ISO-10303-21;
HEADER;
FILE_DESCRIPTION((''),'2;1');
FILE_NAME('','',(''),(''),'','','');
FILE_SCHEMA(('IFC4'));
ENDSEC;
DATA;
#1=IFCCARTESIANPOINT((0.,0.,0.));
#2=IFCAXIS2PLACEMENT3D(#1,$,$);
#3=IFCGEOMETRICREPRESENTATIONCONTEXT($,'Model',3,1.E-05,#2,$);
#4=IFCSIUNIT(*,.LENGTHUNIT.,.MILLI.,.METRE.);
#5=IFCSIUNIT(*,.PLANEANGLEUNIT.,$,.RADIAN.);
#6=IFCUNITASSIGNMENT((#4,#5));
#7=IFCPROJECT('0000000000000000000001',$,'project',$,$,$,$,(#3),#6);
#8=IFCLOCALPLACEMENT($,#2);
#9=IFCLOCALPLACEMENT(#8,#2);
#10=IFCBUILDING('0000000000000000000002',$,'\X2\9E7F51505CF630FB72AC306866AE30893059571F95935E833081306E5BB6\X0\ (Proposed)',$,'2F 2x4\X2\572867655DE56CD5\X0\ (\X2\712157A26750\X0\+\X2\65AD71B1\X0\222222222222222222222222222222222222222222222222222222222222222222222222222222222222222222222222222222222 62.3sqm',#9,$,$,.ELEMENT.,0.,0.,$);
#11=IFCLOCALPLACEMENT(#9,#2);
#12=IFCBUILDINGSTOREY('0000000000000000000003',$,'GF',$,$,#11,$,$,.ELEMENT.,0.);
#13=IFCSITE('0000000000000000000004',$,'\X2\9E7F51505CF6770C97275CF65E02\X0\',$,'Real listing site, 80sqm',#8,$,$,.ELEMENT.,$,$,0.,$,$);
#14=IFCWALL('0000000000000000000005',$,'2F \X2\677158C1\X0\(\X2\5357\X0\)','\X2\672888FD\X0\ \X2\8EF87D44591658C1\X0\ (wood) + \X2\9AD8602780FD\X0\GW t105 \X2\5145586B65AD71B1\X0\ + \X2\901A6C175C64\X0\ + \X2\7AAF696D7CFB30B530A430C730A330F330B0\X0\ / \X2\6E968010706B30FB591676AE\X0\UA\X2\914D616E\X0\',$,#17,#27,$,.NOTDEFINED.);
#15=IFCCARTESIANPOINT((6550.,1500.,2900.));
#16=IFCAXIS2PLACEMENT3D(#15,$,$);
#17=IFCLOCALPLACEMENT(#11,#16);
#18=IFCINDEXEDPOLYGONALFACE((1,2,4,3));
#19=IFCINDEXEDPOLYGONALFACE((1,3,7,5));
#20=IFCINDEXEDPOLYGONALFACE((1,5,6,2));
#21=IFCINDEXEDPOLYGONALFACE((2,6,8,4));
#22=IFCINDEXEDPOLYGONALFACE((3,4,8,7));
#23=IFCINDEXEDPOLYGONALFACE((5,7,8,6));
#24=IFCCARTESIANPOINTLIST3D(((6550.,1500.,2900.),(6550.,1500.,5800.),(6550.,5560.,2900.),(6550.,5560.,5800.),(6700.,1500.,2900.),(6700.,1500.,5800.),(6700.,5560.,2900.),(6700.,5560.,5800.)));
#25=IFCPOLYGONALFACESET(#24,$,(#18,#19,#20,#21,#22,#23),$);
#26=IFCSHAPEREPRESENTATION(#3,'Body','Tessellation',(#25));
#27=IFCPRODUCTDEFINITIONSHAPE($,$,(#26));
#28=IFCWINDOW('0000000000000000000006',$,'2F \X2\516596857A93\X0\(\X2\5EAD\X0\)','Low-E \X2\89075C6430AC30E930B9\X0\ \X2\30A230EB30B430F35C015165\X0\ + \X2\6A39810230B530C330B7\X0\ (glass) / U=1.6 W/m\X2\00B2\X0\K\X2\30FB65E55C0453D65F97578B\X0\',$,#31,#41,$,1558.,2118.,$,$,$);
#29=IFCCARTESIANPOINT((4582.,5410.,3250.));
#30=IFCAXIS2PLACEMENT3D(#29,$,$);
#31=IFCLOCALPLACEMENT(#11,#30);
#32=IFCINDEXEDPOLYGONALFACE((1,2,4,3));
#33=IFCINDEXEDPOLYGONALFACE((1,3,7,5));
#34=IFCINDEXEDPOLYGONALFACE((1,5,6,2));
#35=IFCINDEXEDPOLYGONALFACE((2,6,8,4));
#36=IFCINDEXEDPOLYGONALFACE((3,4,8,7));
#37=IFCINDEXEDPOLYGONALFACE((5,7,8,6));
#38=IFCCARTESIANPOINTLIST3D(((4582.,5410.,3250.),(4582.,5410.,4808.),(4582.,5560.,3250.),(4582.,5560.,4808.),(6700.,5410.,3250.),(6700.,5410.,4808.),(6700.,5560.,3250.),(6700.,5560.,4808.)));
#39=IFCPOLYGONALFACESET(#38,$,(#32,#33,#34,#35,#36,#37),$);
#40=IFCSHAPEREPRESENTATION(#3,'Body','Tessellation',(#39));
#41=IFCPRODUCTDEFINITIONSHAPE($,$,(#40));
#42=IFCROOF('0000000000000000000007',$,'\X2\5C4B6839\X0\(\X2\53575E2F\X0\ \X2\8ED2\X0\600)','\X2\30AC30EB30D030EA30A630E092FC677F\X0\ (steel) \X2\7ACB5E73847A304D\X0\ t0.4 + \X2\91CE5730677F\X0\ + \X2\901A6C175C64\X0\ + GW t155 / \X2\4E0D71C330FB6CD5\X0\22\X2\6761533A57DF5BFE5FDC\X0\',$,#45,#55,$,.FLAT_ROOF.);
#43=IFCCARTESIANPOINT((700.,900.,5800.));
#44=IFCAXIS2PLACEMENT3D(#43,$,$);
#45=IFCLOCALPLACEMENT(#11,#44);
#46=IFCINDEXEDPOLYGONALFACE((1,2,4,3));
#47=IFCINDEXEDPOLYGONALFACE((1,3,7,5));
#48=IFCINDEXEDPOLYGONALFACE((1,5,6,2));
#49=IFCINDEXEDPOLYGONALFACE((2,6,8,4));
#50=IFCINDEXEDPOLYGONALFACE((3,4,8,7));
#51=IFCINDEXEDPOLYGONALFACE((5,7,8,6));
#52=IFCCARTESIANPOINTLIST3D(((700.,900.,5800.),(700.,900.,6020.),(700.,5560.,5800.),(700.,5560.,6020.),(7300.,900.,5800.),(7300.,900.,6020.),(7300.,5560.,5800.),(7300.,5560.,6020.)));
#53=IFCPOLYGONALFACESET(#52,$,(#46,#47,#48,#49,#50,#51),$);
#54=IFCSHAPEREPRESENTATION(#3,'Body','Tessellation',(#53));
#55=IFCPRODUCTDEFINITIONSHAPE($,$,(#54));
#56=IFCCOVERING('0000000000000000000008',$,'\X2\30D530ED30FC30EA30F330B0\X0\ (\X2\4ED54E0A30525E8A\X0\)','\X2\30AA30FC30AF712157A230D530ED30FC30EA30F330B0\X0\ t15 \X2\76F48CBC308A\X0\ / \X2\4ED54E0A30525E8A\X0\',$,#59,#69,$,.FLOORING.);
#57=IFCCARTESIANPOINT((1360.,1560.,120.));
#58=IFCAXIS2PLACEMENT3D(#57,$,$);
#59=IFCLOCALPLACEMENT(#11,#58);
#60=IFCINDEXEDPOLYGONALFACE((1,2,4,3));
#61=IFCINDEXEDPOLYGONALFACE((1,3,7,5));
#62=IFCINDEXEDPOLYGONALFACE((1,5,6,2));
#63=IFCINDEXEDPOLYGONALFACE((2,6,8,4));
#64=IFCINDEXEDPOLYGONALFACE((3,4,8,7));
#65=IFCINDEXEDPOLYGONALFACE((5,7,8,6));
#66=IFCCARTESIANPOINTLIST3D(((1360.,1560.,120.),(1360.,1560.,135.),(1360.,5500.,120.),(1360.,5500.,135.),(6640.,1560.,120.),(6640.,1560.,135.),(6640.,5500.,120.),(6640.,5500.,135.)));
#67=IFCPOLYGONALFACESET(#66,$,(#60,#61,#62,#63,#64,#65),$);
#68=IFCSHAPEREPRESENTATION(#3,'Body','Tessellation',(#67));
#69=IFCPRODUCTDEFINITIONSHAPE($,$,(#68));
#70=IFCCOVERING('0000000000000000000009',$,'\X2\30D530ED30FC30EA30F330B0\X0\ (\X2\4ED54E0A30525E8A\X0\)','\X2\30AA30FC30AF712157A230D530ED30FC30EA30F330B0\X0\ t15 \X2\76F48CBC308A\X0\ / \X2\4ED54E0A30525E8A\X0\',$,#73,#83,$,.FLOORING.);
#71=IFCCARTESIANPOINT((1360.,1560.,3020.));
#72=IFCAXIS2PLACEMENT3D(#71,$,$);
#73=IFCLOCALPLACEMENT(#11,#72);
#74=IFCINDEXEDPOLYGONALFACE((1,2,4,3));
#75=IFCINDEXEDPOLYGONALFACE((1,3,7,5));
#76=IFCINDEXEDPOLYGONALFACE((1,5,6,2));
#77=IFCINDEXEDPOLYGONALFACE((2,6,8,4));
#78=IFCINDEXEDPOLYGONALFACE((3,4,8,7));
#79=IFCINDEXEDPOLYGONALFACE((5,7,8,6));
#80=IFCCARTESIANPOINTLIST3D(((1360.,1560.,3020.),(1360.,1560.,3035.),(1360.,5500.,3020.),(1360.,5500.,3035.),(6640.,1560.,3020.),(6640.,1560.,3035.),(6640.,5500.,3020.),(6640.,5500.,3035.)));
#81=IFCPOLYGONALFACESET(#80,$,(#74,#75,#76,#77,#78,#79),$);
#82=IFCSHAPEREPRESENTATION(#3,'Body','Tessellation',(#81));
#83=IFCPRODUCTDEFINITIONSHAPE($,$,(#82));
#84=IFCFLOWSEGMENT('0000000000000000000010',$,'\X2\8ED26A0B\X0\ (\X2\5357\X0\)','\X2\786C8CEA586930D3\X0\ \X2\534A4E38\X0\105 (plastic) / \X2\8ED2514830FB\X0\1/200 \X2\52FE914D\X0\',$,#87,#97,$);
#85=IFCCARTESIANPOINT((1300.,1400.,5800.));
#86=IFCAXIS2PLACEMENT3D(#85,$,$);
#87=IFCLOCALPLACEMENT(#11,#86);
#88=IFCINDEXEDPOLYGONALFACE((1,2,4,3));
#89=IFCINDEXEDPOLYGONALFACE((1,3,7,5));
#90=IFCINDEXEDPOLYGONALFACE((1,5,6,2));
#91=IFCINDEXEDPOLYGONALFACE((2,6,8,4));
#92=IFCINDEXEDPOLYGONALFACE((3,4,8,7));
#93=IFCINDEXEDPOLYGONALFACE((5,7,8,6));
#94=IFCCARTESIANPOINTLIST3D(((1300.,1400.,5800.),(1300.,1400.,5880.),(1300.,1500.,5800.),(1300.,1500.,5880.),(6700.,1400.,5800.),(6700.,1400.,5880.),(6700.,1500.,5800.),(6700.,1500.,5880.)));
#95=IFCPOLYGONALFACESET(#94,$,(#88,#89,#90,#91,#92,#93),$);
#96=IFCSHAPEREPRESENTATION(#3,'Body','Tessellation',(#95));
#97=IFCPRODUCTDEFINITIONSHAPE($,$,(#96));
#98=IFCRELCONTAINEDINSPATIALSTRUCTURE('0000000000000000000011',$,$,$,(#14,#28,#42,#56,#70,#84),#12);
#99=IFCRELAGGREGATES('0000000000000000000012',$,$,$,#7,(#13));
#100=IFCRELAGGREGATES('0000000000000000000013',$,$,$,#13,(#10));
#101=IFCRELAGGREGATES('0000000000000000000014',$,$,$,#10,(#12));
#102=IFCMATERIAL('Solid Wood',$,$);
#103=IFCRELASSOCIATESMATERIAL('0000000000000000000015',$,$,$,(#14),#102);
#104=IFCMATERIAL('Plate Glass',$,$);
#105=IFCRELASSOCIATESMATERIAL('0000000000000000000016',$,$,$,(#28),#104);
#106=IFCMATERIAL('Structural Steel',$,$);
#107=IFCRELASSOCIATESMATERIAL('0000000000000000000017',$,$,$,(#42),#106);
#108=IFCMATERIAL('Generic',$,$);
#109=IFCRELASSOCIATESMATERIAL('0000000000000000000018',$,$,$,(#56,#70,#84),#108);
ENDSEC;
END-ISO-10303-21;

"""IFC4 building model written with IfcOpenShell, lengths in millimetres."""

from ifc_helpers import new_model, si_unit, frame, frame_2d, origin, place, context, project, spatial, rectangle, extrude, material, element, fill, save


model = new_model("IFC4")

# Units and contexts
model_context = context("Model", 3, precision=1e-05, world=origin())
ifc_project = project(units=[si_unit("LENGTHUNIT", "METRE", prefix="MILLI"), si_unit("PLANEANGLEUNIT", "RADIAN")], contexts=[model_context])

# Site, building, storey
site_placement = place(None, origin())
site = spatial("IfcSite", under=ifc_project, at=site_placement, Name="鹿児島県霧島市", ObjectType="Real listing site, 80sqm", CompositionType="ELEMENT", RefElevation=0.0)
building_placement = place(site_placement, origin())
building = spatial("IfcBuilding", under=site, at=building_placement, Name="鹿児島・犬と暮らす土間広めの家 (Proposed)", ObjectType="2F 2x4在来工法 (無垢材+断熱222222222222222222222222222222222222222222222222222222222222222222222222222222222222222222222222222222222 62.3sqm", CompositionType="ELEMENT", ElevationOfRefHeight=0.0, ElevationOfTerrain=0.0)
storey_placement = place(building_placement, origin())
storey = spatial("IfcBuildingStorey", under=building, at=storey_placement, Name="GF", CompositionType="ELEMENT", Elevation=0.0)

# Shared definitions
ifc_material_1 = material(Name="Solid Wood")

# Wall, opening, window
ifc_material_2 = material(Name="Plate Glass")
wall_1_placement = place(storey_placement, frame((6550.0, 1500.0, 2900.0)))
wall_1 = element("IfcWall", 1, at=wall_1_placement, inside=storey, material=ifc_material_1, Name="2F 東壁(南)", Description="木製 軸組外壁 (wood) + 高性能GW t105 充填断熱 + 通気層 + 窯業系サイディング / 準耐火・外皮UA配慮", PredefinedType="NOTDEFINED", context=model_context, shape_type="SweptSolid", body=[
    extrude(rectangle(XDim=150.0, YDim=4060.0, at=frame_2d((75.0, 2030.0))), frame((6550.0, 1500.0, 2900.0)), (0.0, 0.0, 1.0), 2900.0),
])
opening_1_placement = place(storey_placement, frame((4582.0, 5410.0, 3250.0)))
opening_1 = element("IfcOpeningElement", 2, at=opening_1_placement, cuts=wall_1, PredefinedType="NOTDEFINED", context=model_context, shape_type="SweptSolid", body=[
    extrude(rectangle(XDim=2118.0, YDim=150.0, at=frame_2d((1059.0, 75.0))), frame((4582.0, 5410.0, 3250.0)), (0.0, 0.0, 1.0), 1558.0),
])
window_1_placement = place(storey_placement, frame((4582.0, 5410.0, 3250.0)))
window_1 = element("IfcWindow", 3, at=window_1_placement, inside=storey, material=ifc_material_2, Name="2F 入隅窓(庭)", Description="Low-E 複層ガラス アルゴン封入 + 樹脂サッシ (glass) / U=1.6 W/m²K・日射取得型", OverallHeight=1558.0, OverallWidth=2118.0, context=model_context, shape_type="SweptSolid", body=[
    extrude(rectangle(XDim=2118.0, YDim=150.0, at=frame_2d((1059.0, 75.0))), frame((4582.0, 5410.0, 3250.0)), (0.0, 0.0, 1.0), 1558.0),
])
fill(opening_1, window_1)

# Roof
ifc_material_3 = material(Name="Structural Steel")
for number, where, name in (
    (4, (700.0, 900.0, 5800.0), "屋根(南帯 軒600)"),
):
    element("IfcRoof", number, at=place(storey_placement, frame(where)), inside=storey, material=ifc_material_3, Name=name, Description="ガルバリウム鋼板 (steel) 立平葺き t0.4 + 野地板 + 通気層 + GW t155 / 不燃・法22条区域対応", PredefinedType="FLAT_ROOF", context=model_context, shape_type="SweptSolid", body=[
        extrude(rectangle(XDim=6600.0, YDim=4660.0, at=frame_2d((3300.0, 2330.0))), frame((700.0, 900.0, 5800.0)), (0.0, 0.0, 1.0), 220.0),
    ])

# Coverings
ifc_material_4 = material(Name="Generic")
covering_1_placement = place(storey_placement, frame((1360.0, 1560.0, 120.0)))
element("IfcCovering", 5, at=covering_1_placement, inside=storey, material=ifc_material_4, Name="フローリング (仕上げ床)", Description="オーク無垢フローリング t15 直貼り / 仕上げ床", PredefinedType="FLOORING", context=model_context, shape_type="SweptSolid", body=[
    extrude(rectangle(XDim=5280.0, YDim=3940.0, at=frame_2d((2640.0, 1970.0))), frame((1360.0, 1560.0, 120.0)), (0.0, 0.0, 1.0), 15.0),
])
covering_2_placement = place(storey_placement, frame((1360.0, 1560.0, 3020.0)))
element("IfcCovering", 6, at=covering_2_placement, inside=storey, material=ifc_material_4, Name="フローリング (仕上げ床)", Description="オーク無垢フローリング t15 直貼り / 仕上げ床", PredefinedType="FLOORING", context=model_context, shape_type="SweptSolid", body=[
    extrude(rectangle(XDim=5280.0, YDim=3940.0, at=frame_2d((2640.0, 1970.0))), frame((1360.0, 1560.0, 3020.0)), (0.0, 0.0, 1.0), 15.0),
])

# Flow segment
flow_segment_placement = place(storey_placement, frame((1300.0, 1400.0, 5800.0)))
element("IfcFlowSegment", 7, at=flow_segment_placement, inside=storey, material=ifc_material_4, Name="軒樋 (南)", Description="硬質塩ビ 半丸105 (plastic) / 軒先・1/200 勾配", context=model_context, shape_type="SweptSolid", body=[
    extrude(rectangle(XDim=5400.0, YDim=100.0, at=frame_2d((2700.0, 50.0))), frame((1300.0, 1400.0, 5800.0)), (0.0, 0.0, 1.0), 80.0),
])

save(model, "model.ifc")
